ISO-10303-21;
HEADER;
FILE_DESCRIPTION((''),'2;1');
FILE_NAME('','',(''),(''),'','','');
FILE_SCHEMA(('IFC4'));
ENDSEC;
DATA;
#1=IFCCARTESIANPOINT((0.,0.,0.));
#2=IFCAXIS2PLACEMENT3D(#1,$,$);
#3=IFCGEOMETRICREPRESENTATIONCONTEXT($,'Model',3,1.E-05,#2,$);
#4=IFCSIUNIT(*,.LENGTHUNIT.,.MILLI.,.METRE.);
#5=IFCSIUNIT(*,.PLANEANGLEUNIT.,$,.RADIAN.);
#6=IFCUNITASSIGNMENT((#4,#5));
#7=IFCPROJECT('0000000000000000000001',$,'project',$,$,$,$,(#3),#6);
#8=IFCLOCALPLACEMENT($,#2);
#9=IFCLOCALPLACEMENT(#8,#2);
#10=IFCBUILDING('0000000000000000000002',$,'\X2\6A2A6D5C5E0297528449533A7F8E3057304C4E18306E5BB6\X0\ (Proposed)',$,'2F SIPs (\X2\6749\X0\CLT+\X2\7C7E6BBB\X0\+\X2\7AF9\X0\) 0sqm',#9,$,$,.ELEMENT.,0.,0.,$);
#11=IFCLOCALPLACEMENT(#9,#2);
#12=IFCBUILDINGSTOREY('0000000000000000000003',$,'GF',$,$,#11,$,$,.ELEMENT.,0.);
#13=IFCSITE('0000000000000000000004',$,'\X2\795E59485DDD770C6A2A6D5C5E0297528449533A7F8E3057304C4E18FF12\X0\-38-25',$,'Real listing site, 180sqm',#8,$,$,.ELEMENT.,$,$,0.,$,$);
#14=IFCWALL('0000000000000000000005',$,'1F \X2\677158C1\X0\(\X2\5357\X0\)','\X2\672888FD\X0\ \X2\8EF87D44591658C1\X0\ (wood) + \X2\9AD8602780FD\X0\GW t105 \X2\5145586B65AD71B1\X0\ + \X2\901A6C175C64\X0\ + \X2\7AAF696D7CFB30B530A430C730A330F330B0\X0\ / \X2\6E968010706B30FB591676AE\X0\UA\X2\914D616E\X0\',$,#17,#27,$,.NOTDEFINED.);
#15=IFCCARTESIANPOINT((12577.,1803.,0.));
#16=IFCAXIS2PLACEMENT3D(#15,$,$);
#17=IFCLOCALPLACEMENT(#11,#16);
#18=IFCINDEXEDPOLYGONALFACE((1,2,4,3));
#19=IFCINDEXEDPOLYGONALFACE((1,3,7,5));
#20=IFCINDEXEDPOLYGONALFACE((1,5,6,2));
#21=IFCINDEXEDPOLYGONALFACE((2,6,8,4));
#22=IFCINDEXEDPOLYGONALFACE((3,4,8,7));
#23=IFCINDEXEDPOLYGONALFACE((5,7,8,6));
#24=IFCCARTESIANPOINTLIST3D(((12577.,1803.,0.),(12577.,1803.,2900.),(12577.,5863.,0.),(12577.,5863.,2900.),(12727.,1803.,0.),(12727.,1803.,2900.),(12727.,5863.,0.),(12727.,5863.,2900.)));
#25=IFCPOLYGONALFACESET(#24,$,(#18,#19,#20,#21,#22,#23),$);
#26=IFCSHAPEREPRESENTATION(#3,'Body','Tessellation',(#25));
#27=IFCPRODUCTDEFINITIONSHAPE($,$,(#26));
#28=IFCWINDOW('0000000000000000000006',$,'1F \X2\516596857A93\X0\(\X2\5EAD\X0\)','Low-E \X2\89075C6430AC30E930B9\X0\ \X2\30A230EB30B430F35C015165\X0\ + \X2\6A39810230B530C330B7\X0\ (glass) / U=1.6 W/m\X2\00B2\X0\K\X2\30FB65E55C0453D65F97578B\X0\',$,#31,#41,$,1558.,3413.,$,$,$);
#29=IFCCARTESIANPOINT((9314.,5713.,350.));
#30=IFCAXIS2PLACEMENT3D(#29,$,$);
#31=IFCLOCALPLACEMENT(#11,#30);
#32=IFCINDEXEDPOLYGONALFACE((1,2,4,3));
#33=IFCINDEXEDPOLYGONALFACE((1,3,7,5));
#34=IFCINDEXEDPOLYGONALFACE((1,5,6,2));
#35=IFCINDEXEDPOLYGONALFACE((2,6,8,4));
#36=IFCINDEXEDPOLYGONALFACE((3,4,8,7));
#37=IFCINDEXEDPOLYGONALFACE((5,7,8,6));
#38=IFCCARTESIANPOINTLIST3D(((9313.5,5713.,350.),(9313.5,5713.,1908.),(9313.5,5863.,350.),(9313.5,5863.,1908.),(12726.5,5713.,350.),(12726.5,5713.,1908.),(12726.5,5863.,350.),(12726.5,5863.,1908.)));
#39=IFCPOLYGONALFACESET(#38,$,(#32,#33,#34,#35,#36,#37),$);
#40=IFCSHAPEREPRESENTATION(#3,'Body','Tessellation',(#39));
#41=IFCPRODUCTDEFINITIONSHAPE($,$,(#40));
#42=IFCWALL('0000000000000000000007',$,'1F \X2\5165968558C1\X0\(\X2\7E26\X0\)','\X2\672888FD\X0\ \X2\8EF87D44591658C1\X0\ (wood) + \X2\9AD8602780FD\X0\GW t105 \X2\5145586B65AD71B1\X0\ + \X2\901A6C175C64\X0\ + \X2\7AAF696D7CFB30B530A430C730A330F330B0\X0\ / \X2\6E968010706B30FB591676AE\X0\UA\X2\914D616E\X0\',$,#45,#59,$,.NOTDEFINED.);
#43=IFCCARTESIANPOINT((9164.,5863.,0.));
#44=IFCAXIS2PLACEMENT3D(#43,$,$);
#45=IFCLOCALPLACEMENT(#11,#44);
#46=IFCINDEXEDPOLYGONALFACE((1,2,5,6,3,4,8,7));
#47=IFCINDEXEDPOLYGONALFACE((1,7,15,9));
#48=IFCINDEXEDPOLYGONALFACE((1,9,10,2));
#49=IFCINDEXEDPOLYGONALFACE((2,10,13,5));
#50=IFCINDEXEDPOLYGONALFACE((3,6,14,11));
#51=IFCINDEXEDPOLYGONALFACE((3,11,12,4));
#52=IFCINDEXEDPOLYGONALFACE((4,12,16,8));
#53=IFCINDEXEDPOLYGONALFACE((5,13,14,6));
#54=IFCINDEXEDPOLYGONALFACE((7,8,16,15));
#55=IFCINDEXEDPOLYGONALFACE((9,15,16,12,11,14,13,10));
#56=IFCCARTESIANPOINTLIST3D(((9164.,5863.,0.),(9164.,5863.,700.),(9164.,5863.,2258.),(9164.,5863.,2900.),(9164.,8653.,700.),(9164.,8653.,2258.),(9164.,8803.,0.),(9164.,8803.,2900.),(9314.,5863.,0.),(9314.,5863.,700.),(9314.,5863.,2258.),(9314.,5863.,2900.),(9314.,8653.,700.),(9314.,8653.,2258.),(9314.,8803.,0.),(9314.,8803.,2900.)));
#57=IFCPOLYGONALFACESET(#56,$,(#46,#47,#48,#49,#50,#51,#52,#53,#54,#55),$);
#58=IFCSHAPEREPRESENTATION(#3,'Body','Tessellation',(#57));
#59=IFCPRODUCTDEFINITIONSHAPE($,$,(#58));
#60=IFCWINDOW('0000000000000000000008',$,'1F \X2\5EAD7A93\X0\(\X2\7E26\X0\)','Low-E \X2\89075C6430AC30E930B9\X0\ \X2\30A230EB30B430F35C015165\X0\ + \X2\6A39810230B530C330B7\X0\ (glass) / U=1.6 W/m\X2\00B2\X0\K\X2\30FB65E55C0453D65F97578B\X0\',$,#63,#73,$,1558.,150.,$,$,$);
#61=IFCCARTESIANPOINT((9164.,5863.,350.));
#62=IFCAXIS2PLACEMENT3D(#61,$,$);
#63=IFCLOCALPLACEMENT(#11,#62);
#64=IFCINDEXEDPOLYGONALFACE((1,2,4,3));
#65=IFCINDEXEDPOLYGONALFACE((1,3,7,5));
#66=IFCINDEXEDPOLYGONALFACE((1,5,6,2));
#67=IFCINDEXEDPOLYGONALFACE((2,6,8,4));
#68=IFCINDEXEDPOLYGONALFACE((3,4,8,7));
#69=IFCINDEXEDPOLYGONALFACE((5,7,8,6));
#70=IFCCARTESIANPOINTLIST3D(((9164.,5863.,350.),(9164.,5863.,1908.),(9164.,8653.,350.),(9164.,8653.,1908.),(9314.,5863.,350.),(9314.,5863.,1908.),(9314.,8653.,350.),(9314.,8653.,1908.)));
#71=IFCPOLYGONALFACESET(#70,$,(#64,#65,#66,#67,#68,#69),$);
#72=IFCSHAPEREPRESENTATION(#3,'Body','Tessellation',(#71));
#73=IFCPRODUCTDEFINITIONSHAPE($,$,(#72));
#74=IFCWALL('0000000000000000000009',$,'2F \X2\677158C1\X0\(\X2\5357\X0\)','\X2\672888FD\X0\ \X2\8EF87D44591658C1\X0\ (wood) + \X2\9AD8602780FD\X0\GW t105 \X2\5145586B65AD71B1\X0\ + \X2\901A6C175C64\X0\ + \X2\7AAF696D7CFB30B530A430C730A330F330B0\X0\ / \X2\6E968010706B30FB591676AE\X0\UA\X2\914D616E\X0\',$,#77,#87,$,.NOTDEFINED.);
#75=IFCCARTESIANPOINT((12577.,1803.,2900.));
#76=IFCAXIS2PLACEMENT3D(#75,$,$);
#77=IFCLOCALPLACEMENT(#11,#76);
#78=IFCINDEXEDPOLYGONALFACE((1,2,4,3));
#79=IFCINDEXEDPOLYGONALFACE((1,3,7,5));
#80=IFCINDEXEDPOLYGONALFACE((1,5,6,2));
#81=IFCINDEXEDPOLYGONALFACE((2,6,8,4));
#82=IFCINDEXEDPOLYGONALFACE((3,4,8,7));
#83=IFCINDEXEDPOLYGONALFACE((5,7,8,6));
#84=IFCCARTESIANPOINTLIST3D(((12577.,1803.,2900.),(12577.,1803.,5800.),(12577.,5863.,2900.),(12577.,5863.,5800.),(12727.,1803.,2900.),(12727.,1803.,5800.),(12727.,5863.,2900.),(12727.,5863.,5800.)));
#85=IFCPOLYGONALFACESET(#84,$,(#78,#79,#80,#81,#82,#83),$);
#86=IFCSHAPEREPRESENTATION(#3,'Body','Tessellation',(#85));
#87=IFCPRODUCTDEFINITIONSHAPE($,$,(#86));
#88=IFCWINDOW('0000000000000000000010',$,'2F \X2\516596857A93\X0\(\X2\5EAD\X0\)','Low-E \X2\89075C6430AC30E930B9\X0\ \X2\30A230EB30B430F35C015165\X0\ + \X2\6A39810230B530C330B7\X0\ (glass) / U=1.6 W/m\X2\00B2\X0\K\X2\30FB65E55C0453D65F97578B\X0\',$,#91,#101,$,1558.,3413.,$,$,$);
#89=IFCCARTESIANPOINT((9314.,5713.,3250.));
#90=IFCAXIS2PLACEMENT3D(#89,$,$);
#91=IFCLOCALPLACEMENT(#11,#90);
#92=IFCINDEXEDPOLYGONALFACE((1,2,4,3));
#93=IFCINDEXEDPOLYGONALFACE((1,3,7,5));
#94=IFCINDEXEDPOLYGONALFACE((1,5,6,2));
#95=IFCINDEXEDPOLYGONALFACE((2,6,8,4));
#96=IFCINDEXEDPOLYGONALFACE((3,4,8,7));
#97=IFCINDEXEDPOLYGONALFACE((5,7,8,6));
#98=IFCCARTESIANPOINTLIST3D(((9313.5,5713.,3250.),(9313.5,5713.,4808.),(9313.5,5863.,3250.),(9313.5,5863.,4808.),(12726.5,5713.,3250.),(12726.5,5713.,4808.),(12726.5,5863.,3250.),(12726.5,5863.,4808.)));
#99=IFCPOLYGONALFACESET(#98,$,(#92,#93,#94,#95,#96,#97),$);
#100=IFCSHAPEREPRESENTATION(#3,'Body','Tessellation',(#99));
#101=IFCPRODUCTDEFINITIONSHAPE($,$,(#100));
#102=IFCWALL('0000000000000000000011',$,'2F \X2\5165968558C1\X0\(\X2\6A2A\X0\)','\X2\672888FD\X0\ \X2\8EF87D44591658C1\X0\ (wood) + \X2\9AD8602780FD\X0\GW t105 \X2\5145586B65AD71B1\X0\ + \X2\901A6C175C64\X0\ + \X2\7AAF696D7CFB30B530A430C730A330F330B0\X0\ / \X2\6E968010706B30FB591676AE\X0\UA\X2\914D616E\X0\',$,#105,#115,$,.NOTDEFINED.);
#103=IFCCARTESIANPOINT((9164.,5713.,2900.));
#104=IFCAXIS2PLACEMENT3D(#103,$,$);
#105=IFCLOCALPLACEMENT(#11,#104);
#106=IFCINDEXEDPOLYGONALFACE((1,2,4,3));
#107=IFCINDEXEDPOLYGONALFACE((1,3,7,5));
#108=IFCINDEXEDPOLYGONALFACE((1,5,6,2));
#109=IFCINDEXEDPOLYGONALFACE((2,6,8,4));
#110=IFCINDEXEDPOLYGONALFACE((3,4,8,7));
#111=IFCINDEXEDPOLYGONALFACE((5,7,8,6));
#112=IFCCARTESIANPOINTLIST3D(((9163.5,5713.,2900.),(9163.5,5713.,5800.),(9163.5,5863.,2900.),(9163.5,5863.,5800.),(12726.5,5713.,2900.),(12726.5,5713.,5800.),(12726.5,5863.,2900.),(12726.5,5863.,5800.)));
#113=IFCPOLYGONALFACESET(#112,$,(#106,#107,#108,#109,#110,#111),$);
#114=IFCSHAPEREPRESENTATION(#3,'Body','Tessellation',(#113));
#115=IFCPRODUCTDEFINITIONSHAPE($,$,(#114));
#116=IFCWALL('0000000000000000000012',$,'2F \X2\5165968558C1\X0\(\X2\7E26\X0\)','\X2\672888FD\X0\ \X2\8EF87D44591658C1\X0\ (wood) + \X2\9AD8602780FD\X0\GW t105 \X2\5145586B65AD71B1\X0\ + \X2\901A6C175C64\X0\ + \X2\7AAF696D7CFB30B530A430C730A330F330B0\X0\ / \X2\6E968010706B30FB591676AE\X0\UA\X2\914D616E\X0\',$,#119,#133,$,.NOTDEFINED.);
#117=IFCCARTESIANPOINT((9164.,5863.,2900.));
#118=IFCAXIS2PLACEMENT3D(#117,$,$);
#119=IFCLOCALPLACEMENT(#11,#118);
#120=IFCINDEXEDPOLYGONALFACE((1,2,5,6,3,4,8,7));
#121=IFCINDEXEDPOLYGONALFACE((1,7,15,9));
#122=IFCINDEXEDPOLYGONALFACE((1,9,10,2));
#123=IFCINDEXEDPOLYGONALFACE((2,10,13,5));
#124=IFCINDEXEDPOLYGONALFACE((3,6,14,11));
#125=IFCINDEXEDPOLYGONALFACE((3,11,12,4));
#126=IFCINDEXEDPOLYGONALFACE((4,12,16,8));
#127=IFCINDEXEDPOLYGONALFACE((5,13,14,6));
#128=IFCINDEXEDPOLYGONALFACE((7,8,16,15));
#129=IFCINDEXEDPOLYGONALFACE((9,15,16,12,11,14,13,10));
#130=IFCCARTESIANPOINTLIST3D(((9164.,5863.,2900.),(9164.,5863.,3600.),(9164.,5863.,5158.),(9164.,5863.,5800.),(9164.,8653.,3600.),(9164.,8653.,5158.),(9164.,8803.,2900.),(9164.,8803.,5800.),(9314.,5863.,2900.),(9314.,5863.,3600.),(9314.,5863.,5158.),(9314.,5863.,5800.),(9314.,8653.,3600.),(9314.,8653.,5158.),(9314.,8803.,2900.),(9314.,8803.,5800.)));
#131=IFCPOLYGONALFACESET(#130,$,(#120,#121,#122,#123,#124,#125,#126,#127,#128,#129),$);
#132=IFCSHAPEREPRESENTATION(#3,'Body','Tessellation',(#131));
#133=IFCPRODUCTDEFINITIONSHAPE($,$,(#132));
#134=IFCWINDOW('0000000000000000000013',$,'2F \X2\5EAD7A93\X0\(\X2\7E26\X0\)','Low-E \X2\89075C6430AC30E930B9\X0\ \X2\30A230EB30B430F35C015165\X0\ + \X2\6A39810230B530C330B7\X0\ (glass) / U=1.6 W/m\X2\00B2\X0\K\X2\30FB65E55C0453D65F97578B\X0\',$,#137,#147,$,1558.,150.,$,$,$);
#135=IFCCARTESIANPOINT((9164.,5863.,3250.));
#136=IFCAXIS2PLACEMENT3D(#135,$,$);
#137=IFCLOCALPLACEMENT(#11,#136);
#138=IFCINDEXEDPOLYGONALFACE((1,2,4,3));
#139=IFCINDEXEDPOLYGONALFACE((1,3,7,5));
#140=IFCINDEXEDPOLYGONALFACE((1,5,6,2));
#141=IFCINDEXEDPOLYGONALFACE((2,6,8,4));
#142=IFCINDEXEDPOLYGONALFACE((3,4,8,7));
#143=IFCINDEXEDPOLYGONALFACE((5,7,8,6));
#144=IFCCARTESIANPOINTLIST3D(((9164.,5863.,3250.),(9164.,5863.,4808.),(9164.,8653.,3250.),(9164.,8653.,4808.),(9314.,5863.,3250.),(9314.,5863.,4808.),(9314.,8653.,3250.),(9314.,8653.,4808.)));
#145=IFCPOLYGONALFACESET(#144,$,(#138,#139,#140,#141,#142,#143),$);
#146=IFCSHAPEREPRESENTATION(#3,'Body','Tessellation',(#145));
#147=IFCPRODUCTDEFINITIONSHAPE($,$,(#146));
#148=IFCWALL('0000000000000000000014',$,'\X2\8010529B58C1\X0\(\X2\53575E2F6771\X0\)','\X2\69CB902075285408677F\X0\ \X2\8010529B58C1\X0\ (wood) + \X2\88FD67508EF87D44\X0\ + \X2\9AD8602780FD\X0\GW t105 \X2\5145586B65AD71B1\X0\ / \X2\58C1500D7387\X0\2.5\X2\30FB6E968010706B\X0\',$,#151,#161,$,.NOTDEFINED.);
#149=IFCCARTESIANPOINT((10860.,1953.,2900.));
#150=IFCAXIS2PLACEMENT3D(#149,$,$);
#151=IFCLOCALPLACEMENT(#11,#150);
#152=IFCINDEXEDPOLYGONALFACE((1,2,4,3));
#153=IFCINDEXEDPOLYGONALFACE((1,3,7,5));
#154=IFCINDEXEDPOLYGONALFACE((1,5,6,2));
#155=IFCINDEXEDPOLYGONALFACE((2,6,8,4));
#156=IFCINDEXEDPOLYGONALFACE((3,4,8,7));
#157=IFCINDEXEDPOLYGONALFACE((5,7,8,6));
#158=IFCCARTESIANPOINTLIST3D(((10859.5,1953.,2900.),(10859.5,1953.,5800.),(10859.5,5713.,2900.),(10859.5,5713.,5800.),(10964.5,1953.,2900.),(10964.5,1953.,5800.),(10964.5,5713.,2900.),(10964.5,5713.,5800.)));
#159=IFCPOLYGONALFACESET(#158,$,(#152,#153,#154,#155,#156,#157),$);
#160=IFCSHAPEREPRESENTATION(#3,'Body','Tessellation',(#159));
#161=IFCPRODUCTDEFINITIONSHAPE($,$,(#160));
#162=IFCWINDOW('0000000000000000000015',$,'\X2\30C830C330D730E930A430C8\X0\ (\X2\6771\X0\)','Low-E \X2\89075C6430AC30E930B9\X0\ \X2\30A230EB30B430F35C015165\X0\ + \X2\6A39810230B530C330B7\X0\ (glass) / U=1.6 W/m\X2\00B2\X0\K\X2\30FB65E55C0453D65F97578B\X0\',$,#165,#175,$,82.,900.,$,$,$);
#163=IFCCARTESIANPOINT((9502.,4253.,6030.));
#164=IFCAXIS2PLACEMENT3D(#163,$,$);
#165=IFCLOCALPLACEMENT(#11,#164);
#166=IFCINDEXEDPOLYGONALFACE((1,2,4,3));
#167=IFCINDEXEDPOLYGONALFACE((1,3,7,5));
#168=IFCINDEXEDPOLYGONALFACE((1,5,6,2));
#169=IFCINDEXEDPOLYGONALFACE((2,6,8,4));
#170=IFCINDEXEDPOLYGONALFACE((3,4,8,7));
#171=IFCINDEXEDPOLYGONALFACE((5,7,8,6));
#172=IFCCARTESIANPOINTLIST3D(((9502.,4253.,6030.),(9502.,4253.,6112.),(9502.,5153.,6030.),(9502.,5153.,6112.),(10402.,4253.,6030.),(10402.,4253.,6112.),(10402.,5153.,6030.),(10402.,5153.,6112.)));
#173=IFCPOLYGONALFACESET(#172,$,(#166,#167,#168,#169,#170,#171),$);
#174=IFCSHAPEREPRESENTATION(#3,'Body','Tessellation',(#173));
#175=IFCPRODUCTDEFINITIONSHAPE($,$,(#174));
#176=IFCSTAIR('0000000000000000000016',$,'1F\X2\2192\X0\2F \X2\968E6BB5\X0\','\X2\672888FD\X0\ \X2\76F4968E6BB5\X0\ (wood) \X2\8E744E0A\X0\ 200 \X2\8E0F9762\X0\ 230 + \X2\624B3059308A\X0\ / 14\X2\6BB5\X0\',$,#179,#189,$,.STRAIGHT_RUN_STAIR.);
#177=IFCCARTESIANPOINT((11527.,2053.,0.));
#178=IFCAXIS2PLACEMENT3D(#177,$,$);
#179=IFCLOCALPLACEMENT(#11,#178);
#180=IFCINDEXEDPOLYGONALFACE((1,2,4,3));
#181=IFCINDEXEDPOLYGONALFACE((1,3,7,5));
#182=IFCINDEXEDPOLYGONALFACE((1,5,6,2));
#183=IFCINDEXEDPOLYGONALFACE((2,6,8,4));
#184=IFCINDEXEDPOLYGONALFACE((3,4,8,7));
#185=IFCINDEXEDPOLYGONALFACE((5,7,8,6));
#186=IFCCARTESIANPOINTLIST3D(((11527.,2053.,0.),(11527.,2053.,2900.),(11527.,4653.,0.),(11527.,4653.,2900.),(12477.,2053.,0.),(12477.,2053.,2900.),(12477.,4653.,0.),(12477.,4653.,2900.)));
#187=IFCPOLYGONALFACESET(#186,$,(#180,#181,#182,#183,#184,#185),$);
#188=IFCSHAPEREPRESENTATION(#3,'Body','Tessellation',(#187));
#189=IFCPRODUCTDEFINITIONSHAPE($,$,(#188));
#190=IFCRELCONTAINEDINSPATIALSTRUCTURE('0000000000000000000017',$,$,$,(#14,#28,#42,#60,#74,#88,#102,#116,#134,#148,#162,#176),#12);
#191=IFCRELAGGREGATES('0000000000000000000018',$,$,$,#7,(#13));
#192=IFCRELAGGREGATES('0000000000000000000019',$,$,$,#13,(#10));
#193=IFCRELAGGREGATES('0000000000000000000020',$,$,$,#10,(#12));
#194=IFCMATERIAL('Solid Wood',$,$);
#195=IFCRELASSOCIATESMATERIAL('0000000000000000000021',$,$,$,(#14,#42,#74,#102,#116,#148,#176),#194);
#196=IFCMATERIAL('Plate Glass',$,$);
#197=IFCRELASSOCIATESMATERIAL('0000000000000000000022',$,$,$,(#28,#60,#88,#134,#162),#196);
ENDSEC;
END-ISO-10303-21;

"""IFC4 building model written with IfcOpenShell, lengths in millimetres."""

from ifc_helpers import new_model, si_unit, frame, frame_2d, origin, place, context, project, spatial, rectangle, extrude, material, element, fill, save


model = new_model("IFC4")

# Units and contexts
model_context = context("Model", 3, precision=1e-05, world=origin())
ifc_project = project(units=[si_unit("LENGTHUNIT", "METRE", prefix="MILLI"), si_unit("PLANEANGLEUNIT", "RADIAN")], contexts=[model_context])

# Site, building, storey
site_placement = place(None, origin())
site = spatial("IfcSite", under=ifc_project, at=site_placement, Name="神奈川県横浜市青葉区美しが丘２-38-25", ObjectType="Real listing site, 180sqm", CompositionType="ELEMENT", RefElevation=0.0)
building_placement = place(site_placement, origin())
building = spatial("IfcBuilding", under=site, at=building_placement, Name="横浜市青葉区美しが丘の家 (Proposed)", ObjectType="2F SIPs (杉CLT+籾殻+竹) 0sqm", CompositionType="ELEMENT", ElevationOfRefHeight=0.0, ElevationOfTerrain=0.0)
storey_placement = place(building_placement, origin())
storey = spatial("IfcBuildingStorey", under=building, at=storey_placement, Name="GF", CompositionType="ELEMENT", Elevation=0.0)

# Shared definitions
ifc_material_1 = material(Name="Solid Wood")

# Wall, opening, window
wall_1_placement = place(storey_placement, frame((12577.0, 1803.0, 0.0)))
wall_1 = element("IfcWall", 1, at=wall_1_placement, inside=storey, material=ifc_material_1, Name="1F 東壁(南)", Description="木製 軸組外壁 (wood) + 高性能GW t105 充填断熱 + 通気層 + 窯業系サイディング / 準耐火・外皮UA配慮", PredefinedType="NOTDEFINED", context=model_context, shape_type="SweptSolid", body=[
    extrude(rectangle(XDim=150.0, YDim=4060.0, at=frame_2d((75.0, 2030.0))), frame((12577.0, 1803.0, 0.0)), (0.0, 0.0, 1.0), 2900.0),
])
opening_1_placement = place(storey_placement, frame((9314.0, 5713.0, 350.0)))
opening_1 = element("IfcOpeningElement", 2, at=opening_1_placement, cuts=wall_1, PredefinedType="NOTDEFINED", context=model_context, shape_type="SweptSolid", body=[
    extrude(rectangle(XDim=3413.0, YDim=150.0, at=frame_2d((1706.0, 75.0))), frame((9314.0, 5713.0, 350.0)), (0.0, 0.0, 1.0), 1558.0),
])
ifc_material_2 = material(Name="Plate Glass")
window_1_placement = place(storey_placement, frame((9314.0, 5713.0, 350.0)))
window_1 = element("IfcWindow", 3, at=window_1_placement, inside=storey, material=ifc_material_2, Name="1F 入隅窓(庭)", Description="Low-E 複層ガラス アルゴン封入 + 樹脂サッシ (glass) / U=1.6 W/m²K・日射取得型", OverallHeight=1558.0, OverallWidth=3413.0, context=model_context, shape_type="SweptSolid", body=[
    extrude(rectangle(XDim=3413.0, YDim=150.0, at=frame_2d((1706.0, 75.0))), frame((9314.0, 5713.0, 350.0)), (0.0, 0.0, 1.0), 1558.0),
])
fill(opening_1, window_1)

# Wall, opening, window
wall_2_placement = place(storey_placement, frame((9164.0, 5863.0, 0.0)))
wall_2 = element("IfcWall", 4, at=wall_2_placement, inside=storey, material=ifc_material_1, Name="1F 入隅壁(縦)", Description="木製 軸組外壁 (wood) + 高性能GW t105 充填断熱 + 通気層 + 窯業系サイディング / 準耐火・外皮UA配慮", PredefinedType="NOTDEFINED", context=model_context, shape_type="SweptSolid", body=[
    extrude(rectangle(XDim=150.0, YDim=2940.0, at=frame_2d((75.0, 1470.0))), frame((9164.0, 5863.0, 0.0)), (0.0, 0.0, 1.0), 2900.0),
])
opening_2_placement = place(storey_placement, frame((9164.0, 5863.0, 350.0)))
opening_2 = element("IfcOpeningElement", 5, at=opening_2_placement, cuts=wall_2, PredefinedType="NOTDEFINED", context=model_context, shape_type="SweptSolid", body=[
    extrude(rectangle(XDim=150.0, YDim=2790.0, at=frame_2d((75.0, 1395.0))), frame((9164.0, 5863.0, 350.0)), (0.0, 0.0, 1.0), 1558.0),
])
window_2_placement = place(storey_placement, frame((9164.0, 5863.0, 350.0)))
window_2 = element("IfcWindow", 6, at=window_2_placement, inside=storey, material=ifc_material_2, Name="1F 庭窓(縦)", Description="Low-E 複層ガラス アルゴン封入 + 樹脂サッシ (glass) / U=1.6 W/m²K・日射取得型", OverallHeight=1558.0, OverallWidth=150.0, context=model_context, shape_type="SweptSolid", body=[
    extrude(rectangle(XDim=150.0, YDim=2790.0, at=frame_2d((75.0, 1395.0))), frame((9164.0, 5863.0, 350.0)), (0.0, 0.0, 1.0), 1558.0),
])
fill(opening_2, window_2)

# Wall, opening, window
wall_3_placement = place(storey_placement, frame((12577.0, 1803.0, 2900.0)))
wall_3 = element("IfcWall", 7, at=wall_3_placement, inside=storey, material=ifc_material_1, Name="2F 東壁(南)", Description="木製 軸組外壁 (wood) + 高性能GW t105 充填断熱 + 通気層 + 窯業系サイディング / 準耐火・外皮UA配慮", PredefinedType="NOTDEFINED", context=model_context, shape_type="SweptSolid", body=[
    extrude(rectangle(XDim=150.0, YDim=4060.0, at=frame_2d((75.0, 2030.0))), frame((12577.0, 1803.0, 2900.0)), (0.0, 0.0, 1.0), 2900.0),
])
opening_3_placement = place(storey_placement, frame((9314.0, 5713.0, 3250.0)))
opening_3 = element("IfcOpeningElement", 8, at=opening_3_placement, cuts=wall_3, PredefinedType="NOTDEFINED", context=model_context, shape_type="SweptSolid", body=[
    extrude(rectangle(XDim=3413.0, YDim=150.0, at=frame_2d((1706.0, 75.0))), frame((9314.0, 5713.0, 3250.0)), (0.0, 0.0, 1.0), 1558.0),
])
window_3_placement = place(storey_placement, frame((9314.0, 5713.0, 3250.0)))
window_3 = element("IfcWindow", 9, at=window_3_placement, inside=storey, material=ifc_material_2, Name="2F 入隅窓(庭)", Description="Low-E 複層ガラス アルゴン封入 + 樹脂サッシ (glass) / U=1.6 W/m²K・日射取得型", OverallHeight=1558.0, OverallWidth=3413.0, context=model_context, shape_type="SweptSolid", body=[
    extrude(rectangle(XDim=3413.0, YDim=150.0, at=frame_2d((1706.0, 75.0))), frame((9314.0, 5713.0, 3250.0)), (0.0, 0.0, 1.0), 1558.0),
])
fill(opening_3, window_3)

# Wall
wall_4_placement = place(storey_placement, frame((9164.0, 5713.0, 2900.0)))
element("IfcWall", 10, at=wall_4_placement, inside=storey, material=ifc_material_1, Name="2F 入隅壁(横)", Description="木製 軸組外壁 (wood) + 高性能GW t105 充填断熱 + 通気層 + 窯業系サイディング / 準耐火・外皮UA配慮", PredefinedType="NOTDEFINED", context=model_context, shape_type="SweptSolid", body=[
    extrude(rectangle(XDim=3563.0, YDim=150.0, at=frame_2d((1781.0, 75.0))), frame((9164.0, 5713.0, 2900.0)), (0.0, 0.0, 1.0), 2900.0),
])

# Wall, opening, window
wall_5_placement = place(storey_placement, frame((9164.0, 5863.0, 2900.0)))
wall_5 = element("IfcWall", 11, at=wall_5_placement, inside=storey, material=ifc_material_1, Name="2F 入隅壁(縦)", Description="木製 軸組外壁 (wood) + 高性能GW t105 充填断熱 + 通気層 + 窯業系サイディング / 準耐火・外皮UA配慮", PredefinedType="NOTDEFINED", context=model_context, shape_type="SweptSolid", body=[
    extrude(rectangle(XDim=150.0, YDim=2940.0, at=frame_2d((75.0, 1470.0))), frame((9164.0, 5863.0, 2900.0)), (0.0, 0.0, 1.0), 2900.0),
])
opening_4_placement = place(storey_placement, frame((9164.0, 5863.0, 3250.0)))
opening_4 = element("IfcOpeningElement", 12, at=opening_4_placement, cuts=wall_5, PredefinedType="NOTDEFINED", context=model_context, shape_type="SweptSolid", body=[
    extrude(rectangle(XDim=150.0, YDim=2790.0, at=frame_2d((75.0, 1395.0))), frame((9164.0, 5863.0, 3250.0)), (0.0, 0.0, 1.0), 1558.0),
])
window_4_placement = place(storey_placement, frame((9164.0, 5863.0, 3250.0)))
window_4 = element("IfcWindow", 13, at=window_4_placement, inside=storey, material=ifc_material_2, Name="2F 庭窓(縦)", Description="Low-E 複層ガラス アルゴン封入 + 樹脂サッシ (glass) / U=1.6 W/m²K・日射取得型", OverallHeight=1558.0, OverallWidth=150.0, context=model_context, shape_type="SweptSolid", body=[
    extrude(rectangle(XDim=150.0, YDim=2790.0, at=frame_2d((75.0, 1395.0))), frame((9164.0, 5863.0, 3250.0)), (0.0, 0.0, 1.0), 1558.0),
])
fill(opening_4, window_4)

# Wall
wall_6_placement = place(storey_placement, frame((10860.0, 1953.0, 2900.0)))
element("IfcWall", 14, at=wall_6_placement, inside=storey, material=ifc_material_1, Name="耐力壁(南帯東)", Description="構造用合板 耐力壁 (wood) + 製材軸組 + 高性能GW t105 充填断熱 / 壁倍率2.5・準耐火", PredefinedType="NOTDEFINED", context=model_context, shape_type="SweptSolid", body=[
    extrude(rectangle(XDim=105.0, YDim=3760.0, at=frame_2d((52.0, 1880.0))), frame((10860.0, 1953.0, 2900.0)), (0.0, 0.0, 1.0), 2900.0),
])

# Window
window_5_placement = place(storey_placement, frame((9502.0, 4253.0, 6030.0)))
element("IfcWindow", 15, at=window_5_placement, inside=storey, material=ifc_material_2, Name="トップライト (東)", Description="Low-E 複層ガラス アルゴン封入 + 樹脂サッシ (glass) / U=1.6 W/m²K・日射取得型", OverallHeight=82.0, OverallWidth=900.0, context=model_context, shape_type="SweptSolid", body=[
    extrude(rectangle(XDim=900.0, YDim=900.0, at=frame_2d((450.0, 450.0))), frame((9502.0, 4253.0, 6030.0)), (0.0, 0.0, 1.0), 82.0),
])

# Stair
stair_placement = place(storey_placement, frame((11527.0, 2053.0, 0.0)))
element("IfcStair", 16, at=stair_placement, inside=storey, material=ifc_material_1, Name="1F→2F 階段", Description="木製 直階段 (wood) 蹴上 200 踏面 230 + 手すり / 14段", PredefinedType="STRAIGHT_RUN_STAIR", context=model_context, shape_type="SweptSolid", body=[
    extrude(rectangle(XDim=950.0, YDim=2600.0, at=frame_2d((475.0, 1300.0))), frame((11527.0, 2053.0, 0.0)), (0.0, 0.0, 1.0), 2900.0),
])

save(model, "model.ifc")
